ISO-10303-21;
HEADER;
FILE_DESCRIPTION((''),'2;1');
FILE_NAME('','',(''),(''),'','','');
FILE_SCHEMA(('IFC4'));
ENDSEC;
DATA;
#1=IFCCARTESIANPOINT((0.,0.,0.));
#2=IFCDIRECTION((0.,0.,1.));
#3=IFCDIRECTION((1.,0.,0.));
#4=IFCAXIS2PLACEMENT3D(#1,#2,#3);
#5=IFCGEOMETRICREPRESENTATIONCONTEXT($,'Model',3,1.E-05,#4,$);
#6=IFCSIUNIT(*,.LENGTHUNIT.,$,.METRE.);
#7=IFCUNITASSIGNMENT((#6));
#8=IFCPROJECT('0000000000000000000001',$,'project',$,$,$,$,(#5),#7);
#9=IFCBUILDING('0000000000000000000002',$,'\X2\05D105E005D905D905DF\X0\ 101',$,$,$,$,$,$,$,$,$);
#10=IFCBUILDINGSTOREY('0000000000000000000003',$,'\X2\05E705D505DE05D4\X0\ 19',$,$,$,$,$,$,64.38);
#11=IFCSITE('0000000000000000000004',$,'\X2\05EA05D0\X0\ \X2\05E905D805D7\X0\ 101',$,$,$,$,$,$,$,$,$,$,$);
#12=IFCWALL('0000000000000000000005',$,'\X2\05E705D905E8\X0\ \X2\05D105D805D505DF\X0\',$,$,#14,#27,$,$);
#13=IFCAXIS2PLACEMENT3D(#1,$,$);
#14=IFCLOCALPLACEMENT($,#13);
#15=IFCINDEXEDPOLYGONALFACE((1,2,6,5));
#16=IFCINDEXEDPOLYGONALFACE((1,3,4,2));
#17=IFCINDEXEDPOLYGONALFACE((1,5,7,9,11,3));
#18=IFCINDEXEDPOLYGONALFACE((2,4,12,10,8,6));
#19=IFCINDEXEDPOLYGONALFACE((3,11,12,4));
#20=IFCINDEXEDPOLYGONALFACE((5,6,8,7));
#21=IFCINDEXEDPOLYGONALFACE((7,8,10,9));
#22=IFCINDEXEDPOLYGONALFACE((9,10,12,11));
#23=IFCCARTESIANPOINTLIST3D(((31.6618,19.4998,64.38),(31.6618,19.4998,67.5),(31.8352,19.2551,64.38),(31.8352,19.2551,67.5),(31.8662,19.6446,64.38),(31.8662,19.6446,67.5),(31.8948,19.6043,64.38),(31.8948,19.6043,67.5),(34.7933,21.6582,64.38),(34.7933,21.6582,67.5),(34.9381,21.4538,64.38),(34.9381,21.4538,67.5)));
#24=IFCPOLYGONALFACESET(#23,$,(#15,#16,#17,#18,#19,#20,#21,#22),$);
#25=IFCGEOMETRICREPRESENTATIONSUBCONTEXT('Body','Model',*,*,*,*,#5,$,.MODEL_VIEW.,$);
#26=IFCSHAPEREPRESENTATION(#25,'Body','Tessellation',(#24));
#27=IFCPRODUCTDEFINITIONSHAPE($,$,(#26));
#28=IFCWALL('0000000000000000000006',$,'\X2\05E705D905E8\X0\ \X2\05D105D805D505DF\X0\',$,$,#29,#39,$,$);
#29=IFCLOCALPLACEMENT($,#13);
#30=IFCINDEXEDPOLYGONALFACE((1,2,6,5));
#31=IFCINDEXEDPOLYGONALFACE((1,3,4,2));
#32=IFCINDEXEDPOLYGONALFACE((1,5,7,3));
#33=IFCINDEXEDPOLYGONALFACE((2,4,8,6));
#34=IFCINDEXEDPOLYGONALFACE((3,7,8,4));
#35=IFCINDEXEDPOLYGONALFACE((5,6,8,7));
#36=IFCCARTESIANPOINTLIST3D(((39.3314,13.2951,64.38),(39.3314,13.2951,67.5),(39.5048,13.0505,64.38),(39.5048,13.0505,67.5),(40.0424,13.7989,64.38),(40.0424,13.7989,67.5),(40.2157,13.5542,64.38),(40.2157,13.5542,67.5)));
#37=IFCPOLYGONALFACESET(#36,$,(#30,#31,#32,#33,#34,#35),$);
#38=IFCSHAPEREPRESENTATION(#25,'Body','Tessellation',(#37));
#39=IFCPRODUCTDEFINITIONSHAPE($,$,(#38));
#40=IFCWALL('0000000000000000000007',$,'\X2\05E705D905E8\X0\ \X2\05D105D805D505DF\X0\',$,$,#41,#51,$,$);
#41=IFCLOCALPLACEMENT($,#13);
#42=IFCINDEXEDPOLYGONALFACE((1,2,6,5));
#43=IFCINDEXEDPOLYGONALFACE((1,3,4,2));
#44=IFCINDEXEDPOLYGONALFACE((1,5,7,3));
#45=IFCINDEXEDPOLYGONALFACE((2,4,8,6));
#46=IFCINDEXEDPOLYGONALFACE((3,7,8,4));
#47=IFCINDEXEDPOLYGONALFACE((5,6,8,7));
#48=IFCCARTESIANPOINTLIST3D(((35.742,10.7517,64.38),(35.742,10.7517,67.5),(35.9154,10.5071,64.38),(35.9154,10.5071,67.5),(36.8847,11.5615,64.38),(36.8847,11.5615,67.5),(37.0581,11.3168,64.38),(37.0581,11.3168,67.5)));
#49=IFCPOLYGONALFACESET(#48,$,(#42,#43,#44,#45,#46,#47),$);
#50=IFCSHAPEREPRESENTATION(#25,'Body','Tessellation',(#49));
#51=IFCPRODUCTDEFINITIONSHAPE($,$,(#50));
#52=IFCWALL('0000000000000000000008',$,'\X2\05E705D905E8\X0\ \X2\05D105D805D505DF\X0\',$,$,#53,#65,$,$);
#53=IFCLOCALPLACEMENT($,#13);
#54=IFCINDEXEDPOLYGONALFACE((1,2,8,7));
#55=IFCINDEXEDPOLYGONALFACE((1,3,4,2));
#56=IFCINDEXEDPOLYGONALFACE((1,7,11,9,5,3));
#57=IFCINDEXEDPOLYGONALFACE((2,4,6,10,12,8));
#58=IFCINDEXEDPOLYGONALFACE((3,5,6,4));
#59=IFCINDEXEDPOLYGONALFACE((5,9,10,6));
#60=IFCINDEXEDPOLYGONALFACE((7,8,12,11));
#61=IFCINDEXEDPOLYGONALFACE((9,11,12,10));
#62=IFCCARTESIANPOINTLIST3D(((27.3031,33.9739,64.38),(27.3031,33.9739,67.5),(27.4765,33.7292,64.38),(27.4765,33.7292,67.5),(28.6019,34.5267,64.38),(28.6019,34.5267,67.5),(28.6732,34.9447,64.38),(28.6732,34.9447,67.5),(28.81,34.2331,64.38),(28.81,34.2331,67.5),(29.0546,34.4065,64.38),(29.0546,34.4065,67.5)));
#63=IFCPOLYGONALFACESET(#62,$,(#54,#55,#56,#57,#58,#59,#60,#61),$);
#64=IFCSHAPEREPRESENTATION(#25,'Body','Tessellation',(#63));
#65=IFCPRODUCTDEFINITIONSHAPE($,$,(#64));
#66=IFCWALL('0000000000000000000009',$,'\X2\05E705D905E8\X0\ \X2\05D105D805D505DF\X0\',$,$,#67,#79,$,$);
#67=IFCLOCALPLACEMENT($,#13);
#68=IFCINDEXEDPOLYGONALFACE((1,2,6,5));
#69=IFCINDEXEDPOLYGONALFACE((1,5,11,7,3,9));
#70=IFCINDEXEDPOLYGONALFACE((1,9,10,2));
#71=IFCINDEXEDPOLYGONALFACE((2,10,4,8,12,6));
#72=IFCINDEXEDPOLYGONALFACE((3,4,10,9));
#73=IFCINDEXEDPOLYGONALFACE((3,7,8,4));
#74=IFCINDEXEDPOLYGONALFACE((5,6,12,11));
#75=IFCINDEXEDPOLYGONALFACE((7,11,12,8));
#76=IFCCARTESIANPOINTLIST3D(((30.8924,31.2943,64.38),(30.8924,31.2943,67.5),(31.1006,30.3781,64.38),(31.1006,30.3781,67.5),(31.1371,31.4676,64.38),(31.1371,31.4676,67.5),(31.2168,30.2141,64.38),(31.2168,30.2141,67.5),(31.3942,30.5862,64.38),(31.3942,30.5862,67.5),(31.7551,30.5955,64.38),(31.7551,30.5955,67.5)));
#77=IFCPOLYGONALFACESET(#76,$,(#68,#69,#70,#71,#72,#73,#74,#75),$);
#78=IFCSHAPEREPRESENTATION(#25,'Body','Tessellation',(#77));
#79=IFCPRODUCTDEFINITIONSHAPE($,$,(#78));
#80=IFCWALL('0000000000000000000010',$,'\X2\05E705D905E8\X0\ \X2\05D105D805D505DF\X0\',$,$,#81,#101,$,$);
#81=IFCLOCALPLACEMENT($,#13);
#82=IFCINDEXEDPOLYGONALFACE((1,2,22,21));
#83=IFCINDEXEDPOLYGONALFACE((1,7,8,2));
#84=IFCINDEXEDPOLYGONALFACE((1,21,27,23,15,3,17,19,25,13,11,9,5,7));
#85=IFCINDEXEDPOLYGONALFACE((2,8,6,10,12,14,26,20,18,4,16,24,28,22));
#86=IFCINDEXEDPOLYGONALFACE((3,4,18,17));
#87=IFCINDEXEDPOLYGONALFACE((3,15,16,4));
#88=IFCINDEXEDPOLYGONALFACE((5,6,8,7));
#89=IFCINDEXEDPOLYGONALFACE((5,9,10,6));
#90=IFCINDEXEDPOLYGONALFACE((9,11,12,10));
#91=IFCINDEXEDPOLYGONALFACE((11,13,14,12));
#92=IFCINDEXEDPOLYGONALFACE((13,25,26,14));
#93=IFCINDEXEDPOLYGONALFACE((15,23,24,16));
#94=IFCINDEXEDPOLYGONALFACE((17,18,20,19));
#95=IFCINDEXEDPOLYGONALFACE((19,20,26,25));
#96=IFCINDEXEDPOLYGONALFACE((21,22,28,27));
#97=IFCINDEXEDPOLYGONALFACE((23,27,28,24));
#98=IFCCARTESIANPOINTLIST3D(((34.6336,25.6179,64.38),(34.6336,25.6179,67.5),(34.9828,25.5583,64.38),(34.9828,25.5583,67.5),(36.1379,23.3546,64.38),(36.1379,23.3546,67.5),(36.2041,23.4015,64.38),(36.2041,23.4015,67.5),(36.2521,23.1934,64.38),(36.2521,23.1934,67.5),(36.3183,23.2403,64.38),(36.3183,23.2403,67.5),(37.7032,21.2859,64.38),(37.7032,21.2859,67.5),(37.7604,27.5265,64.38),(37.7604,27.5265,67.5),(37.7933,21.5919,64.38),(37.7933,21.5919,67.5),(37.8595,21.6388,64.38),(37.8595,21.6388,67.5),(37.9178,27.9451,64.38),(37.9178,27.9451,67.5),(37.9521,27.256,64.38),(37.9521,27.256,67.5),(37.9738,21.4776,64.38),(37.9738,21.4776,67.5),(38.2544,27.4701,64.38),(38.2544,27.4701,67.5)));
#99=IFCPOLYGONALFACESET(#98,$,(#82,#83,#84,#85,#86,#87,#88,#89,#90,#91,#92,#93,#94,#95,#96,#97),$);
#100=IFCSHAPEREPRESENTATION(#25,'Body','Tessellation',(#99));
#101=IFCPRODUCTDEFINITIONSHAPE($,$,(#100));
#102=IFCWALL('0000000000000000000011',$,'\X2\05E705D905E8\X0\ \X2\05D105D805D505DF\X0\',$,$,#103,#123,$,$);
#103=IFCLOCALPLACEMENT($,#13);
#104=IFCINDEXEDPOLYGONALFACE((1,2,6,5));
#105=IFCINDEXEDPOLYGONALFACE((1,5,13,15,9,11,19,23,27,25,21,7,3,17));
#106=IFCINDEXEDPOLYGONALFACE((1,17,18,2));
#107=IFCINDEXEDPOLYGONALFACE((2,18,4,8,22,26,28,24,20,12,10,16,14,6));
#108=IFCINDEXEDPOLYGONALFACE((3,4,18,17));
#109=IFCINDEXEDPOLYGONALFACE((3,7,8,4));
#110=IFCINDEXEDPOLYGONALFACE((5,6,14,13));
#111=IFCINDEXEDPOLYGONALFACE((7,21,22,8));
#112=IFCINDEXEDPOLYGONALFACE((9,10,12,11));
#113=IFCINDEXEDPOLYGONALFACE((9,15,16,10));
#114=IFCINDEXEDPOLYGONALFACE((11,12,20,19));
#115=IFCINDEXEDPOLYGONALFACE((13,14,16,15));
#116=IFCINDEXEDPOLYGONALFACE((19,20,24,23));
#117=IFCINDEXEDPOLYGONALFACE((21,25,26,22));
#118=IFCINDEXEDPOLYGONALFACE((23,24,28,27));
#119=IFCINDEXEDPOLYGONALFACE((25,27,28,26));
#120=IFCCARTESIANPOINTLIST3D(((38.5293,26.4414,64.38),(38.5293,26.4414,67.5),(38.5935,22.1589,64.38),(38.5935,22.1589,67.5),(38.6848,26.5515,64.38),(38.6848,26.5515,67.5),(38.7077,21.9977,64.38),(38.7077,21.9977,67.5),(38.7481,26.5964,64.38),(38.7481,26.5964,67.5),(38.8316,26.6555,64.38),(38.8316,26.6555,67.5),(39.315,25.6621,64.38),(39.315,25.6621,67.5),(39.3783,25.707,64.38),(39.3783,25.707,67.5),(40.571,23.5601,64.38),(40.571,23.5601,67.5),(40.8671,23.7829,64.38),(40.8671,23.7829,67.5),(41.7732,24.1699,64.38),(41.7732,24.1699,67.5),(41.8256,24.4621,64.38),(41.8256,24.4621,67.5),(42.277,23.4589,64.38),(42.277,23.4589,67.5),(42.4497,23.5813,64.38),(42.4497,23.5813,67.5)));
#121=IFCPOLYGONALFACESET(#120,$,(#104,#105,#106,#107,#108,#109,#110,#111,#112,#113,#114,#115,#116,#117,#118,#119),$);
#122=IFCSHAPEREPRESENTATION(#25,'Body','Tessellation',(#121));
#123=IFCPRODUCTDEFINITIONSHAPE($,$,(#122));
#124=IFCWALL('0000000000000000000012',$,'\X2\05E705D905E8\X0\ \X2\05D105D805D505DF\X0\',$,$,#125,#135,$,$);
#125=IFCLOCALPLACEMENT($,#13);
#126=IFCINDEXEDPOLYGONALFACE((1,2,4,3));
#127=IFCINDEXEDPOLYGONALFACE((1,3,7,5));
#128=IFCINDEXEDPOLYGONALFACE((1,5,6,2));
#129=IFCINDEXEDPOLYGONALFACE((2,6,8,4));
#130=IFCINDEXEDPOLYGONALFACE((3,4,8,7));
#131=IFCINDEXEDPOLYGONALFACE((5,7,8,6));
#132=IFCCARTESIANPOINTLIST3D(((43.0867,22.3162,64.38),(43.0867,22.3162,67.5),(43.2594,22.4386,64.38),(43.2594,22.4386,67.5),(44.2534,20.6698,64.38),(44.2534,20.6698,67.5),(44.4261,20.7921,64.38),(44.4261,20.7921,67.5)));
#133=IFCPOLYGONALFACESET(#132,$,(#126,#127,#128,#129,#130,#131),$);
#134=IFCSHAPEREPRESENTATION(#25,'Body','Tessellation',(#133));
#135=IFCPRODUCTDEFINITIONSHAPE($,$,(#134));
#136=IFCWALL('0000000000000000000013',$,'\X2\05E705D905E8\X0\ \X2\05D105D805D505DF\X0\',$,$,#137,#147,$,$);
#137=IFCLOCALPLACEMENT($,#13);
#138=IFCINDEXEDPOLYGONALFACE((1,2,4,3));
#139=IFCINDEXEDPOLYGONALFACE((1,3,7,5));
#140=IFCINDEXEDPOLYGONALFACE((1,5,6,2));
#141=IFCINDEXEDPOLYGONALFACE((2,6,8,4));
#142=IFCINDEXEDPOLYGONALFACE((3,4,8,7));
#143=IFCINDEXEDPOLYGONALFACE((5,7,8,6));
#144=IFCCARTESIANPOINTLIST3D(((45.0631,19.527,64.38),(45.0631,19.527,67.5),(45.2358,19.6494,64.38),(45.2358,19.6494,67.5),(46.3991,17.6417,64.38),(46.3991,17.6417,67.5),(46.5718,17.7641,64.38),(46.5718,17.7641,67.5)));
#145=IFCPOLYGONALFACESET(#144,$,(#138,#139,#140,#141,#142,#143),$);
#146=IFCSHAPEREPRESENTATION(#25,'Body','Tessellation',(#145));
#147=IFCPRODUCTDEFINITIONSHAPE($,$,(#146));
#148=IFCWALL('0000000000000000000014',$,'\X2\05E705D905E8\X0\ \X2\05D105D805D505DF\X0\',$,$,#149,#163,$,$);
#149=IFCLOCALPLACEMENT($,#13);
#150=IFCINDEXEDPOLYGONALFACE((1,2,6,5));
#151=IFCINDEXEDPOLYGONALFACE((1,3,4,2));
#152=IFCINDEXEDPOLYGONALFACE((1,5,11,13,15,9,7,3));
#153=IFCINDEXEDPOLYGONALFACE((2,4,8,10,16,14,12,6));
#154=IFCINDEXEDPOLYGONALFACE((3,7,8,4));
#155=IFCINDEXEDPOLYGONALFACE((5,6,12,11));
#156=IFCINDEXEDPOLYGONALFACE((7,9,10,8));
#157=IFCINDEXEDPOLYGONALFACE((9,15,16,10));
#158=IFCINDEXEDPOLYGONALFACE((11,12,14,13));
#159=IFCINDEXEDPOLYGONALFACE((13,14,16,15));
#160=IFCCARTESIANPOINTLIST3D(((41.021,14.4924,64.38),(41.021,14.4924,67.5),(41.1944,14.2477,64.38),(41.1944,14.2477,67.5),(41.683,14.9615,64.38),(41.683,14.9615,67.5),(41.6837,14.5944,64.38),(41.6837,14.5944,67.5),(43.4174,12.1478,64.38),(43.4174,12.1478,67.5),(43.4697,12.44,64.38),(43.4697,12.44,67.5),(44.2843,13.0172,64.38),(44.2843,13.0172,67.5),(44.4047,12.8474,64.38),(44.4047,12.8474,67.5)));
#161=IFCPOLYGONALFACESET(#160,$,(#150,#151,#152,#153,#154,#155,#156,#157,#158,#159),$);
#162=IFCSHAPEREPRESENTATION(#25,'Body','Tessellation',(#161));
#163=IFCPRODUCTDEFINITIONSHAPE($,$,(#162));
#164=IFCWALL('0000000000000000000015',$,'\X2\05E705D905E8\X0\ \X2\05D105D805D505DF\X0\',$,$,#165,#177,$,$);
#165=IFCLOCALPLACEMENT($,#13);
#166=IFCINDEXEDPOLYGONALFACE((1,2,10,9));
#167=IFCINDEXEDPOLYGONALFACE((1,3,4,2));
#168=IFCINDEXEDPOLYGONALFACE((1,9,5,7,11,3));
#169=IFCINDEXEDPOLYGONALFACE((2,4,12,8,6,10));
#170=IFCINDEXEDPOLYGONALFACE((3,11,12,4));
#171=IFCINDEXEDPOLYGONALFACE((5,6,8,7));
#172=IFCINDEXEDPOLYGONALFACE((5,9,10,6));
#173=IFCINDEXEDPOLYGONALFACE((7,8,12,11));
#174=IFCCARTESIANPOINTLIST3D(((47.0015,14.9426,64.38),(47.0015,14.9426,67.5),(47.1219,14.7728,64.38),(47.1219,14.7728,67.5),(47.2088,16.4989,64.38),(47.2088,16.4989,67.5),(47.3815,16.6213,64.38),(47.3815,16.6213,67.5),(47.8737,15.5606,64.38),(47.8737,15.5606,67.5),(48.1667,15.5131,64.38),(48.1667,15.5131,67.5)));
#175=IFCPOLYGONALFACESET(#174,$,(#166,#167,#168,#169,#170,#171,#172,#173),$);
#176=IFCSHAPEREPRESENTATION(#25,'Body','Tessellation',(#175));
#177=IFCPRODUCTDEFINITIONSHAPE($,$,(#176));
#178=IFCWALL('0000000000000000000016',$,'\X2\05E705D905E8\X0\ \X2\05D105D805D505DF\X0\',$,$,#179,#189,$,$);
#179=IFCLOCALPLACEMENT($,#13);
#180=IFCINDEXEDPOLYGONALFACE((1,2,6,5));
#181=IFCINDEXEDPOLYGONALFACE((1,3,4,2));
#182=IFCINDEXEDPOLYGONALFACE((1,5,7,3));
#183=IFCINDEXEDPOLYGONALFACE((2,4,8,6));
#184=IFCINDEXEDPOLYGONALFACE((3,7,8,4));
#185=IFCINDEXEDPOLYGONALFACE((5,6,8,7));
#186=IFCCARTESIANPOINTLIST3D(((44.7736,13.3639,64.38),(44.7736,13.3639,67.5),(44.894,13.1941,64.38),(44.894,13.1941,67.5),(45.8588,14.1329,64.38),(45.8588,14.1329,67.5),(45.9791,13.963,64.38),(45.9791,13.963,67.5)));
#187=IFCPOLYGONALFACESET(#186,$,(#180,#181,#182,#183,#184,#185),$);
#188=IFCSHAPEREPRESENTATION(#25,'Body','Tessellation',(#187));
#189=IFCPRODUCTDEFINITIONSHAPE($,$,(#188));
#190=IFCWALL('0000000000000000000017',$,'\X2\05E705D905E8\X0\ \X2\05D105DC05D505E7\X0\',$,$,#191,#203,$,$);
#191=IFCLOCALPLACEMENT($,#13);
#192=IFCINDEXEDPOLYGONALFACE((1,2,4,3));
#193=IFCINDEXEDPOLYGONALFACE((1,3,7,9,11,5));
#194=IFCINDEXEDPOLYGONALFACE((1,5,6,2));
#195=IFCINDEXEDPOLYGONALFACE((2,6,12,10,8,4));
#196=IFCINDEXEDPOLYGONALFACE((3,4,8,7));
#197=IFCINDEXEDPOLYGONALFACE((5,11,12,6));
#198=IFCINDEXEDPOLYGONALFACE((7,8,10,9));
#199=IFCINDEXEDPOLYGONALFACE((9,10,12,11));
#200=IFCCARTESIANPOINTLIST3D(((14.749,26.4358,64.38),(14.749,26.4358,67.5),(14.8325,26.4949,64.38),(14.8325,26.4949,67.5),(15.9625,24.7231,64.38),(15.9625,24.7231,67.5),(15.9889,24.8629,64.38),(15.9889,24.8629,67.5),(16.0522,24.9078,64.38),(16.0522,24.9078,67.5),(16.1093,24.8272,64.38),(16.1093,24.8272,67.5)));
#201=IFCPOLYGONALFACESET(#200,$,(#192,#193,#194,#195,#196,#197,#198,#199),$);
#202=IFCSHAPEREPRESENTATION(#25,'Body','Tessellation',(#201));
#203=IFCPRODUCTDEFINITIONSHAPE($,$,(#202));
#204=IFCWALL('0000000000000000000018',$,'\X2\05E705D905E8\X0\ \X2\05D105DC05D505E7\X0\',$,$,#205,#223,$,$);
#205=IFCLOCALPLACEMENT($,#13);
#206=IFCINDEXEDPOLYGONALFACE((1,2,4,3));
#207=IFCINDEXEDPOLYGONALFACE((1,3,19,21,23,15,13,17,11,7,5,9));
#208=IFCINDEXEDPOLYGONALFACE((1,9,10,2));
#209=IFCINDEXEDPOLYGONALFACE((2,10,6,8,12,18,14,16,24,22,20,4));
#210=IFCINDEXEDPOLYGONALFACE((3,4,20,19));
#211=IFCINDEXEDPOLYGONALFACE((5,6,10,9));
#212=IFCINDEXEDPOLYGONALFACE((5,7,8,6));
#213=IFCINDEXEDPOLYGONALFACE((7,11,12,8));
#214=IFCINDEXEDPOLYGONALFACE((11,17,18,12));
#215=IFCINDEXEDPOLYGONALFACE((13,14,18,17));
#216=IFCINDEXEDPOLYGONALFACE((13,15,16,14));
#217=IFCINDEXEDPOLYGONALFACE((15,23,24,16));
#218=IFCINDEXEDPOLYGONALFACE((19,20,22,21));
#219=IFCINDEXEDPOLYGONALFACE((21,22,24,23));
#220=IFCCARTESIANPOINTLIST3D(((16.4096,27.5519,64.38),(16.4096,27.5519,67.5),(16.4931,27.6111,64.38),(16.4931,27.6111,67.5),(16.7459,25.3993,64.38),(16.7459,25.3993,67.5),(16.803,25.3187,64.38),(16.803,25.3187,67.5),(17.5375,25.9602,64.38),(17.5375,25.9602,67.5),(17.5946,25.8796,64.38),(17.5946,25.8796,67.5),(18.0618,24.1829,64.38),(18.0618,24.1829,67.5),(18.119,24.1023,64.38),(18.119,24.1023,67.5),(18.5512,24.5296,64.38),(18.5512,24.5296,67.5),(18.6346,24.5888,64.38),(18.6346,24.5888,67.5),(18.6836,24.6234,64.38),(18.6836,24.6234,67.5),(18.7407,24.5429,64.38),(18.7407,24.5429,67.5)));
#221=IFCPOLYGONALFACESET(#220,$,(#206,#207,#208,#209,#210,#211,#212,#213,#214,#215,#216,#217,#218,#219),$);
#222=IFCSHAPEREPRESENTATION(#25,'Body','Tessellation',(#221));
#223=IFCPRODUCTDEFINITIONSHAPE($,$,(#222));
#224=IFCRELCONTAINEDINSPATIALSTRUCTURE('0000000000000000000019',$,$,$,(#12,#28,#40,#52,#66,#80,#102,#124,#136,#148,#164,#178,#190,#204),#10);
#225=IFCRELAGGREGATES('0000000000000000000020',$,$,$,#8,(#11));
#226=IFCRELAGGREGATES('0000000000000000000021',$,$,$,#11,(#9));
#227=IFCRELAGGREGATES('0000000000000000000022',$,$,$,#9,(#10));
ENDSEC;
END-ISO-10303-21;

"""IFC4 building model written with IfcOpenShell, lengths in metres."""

from ifc_helpers import new_model, si_unit, frame, origin_with_axes, context, subcontext, project, spatial, polyline, outline, extrude, element, save


model = new_model("IFC4")

# Units and contexts
model_context = context("Model", 3, precision=1e-05, world=origin_with_axes())
body_context = subcontext(model_context, "Body", "Model", "MODEL_VIEW")
ifc_project = project(units=[si_unit("LENGTHUNIT", "METRE")], contexts=[model_context])

# Site, building, storey
site = spatial("IfcSite", under=ifc_project, Name="תא שטח 101")
building = spatial("IfcBuilding", under=site, Name="בניין 101")
storey = spatial("IfcBuildingStorey", under=building, Name="קומה 19", Elevation=64.38)

# Walls
element("IfcWall", 1, inside=storey, Name="קיר בטון", context=body_context, shape_type="SweptSolid", body=[
    extrude(outline(polyline([(31.6618, 19.4998), (31.8352, 19.2551), (34.9381, 21.4538), (34.7933, 21.6582), (31.8948, 19.6043), (31.8662, 19.6446), (31.6618, 19.4998)])), frame((0.0, 0.0, 64.38)), (0.0, 0.0, 1.0), 3.12),
])
element("IfcWall", 2, inside=storey, Name="קיר בטון", context=body_context, shape_type="SweptSolid", body=[
    extrude(outline(polyline([(40.2157, 13.5542), (40.0424, 13.7989), (39.3314, 13.2951), (39.5048, 13.0505), (40.2157, 13.5542)])), frame((0.0, 0.0, 64.38)), (0.0, 0.0, 1.0), 3.12),
])
element("IfcWall", 3, inside=storey, Name="קיר בטון", context=body_context, shape_type="SweptSolid", body=[
    extrude(outline(polyline([(37.0581, 11.3168), (36.8847, 11.5615), (35.742, 10.7517), (35.9154, 10.5071), (37.0581, 11.3168)])), frame((0.0, 0.0, 64.38)), (0.0, 0.0, 1.0), 3.12),
])
element("IfcWall", 4, inside=storey, Name="קיר בטון", context=body_context, shape_type="SweptSolid", body=[
    extrude(outline(polyline([(28.81, 34.2331), (29.0546, 34.4065), (28.6732, 34.9447), (27.3031, 33.9739), (27.4765, 33.7292), (28.6019, 34.5267), (28.81, 34.2331)])), frame((0.0, 0.0, 64.38)), (0.0, 0.0, 1.0), 3.12),
])
element("IfcWall", 5, inside=storey, Name="קיר בטון", context=body_context, shape_type="SweptSolid", body=[
    extrude(outline(polyline([(31.2168, 30.2141), (31.7551, 30.5955), (31.1371, 31.4676), (30.8924, 31.2943), (31.3942, 30.5862), (31.1006, 30.3781), (31.2168, 30.2141)])), frame((0.0, 0.0, 64.38)), (0.0, 0.0, 1.0), 3.12),
])
element("IfcWall", 6, inside=storey, Name="קיר בטון", context=body_context, shape_type="SweptSolid", body=[
    extrude(outline(polyline([(36.2521, 23.1934), (36.3183, 23.2403), (37.7032, 21.2859), (37.9738, 21.4776), (37.8595, 21.6388), (37.7933, 21.5919), (34.9828, 25.5583), (37.7604, 27.5265), (37.9521, 27.256), (38.2544, 27.4701), (37.9178, 27.9451), (34.6336, 25.6179), (36.2041, 23.4015), (36.1379, 23.3546), (36.2521, 23.1934)])), frame((0.0, 0.0, 64.38)), (0.0, 0.0, 1.0), 3.12),
])
element("IfcWall", 7, inside=storey, Name="קיר בטון", context=body_context, shape_type="SweptSolid", body=[
    extrude(outline(polyline([(38.5293, 26.4414), (40.571, 23.5601), (38.5935, 22.1589), (38.7077, 21.9977), (41.7732, 24.1699), (42.277, 23.4589), (42.4497, 23.5813), (41.8256, 24.4621), (40.8671, 23.7829), (38.8316, 26.6555), (38.7481, 26.5964), (39.3783, 25.707), (39.315, 25.6621), (38.6848, 26.5515), (38.5293, 26.4414)])), frame((0.0, 0.0, 64.38)), (0.0, 0.0, 1.0), 3.12),
])
element("IfcWall", 8, inside=storey, Name="קיר בטון", context=body_context, shape_type="SweptSolid", body=[
    extrude(outline(polyline([(43.2594, 22.4386), (43.0867, 22.3162), (44.2534, 20.6698), (44.4261, 20.7921), (43.2594, 22.4386)])), frame((0.0, 0.0, 64.38)), (0.0, 0.0, 1.0), 3.12),
])
element("IfcWall", 9, inside=storey, Name="קיר בטון", context=body_context, shape_type="SweptSolid", body=[
    extrude(outline(polyline([(46.3991, 17.6417), (46.5718, 17.7641), (45.2358, 19.6494), (45.0631, 19.527), (46.3991, 17.6417)])), frame((0.0, 0.0, 64.38)), (0.0, 0.0, 1.0), 3.12),
])
element("IfcWall", 10, inside=storey, Name="קיר בטון", context=body_context, shape_type="SweptSolid", body=[
    extrude(outline(polyline([(43.4174, 12.1478), (44.4047, 12.8474), (44.2843, 13.0172), (43.4697, 12.44), (41.683, 14.9615), (41.021, 14.4924), (41.1944, 14.2477), (41.6837, 14.5944), (43.4174, 12.1478)])), frame((0.0, 0.0, 64.38)), (0.0, 0.0, 1.0), 3.12),
])
element("IfcWall", 11, inside=storey, Name="קיר בטון", context=body_context, shape_type="SweptSolid", body=[
    extrude(outline(polyline([(47.1219, 14.7728), (48.1667, 15.5131), (47.3815, 16.6213), (47.2088, 16.4989), (47.8737, 15.5606), (47.0015, 14.9426), (47.1219, 14.7728)])), frame((0.0, 0.0, 64.38)), (0.0, 0.0, 1.0), 3.12),
])
element("IfcWall", 12, inside=storey, Name="קיר בטון", context=body_context, shape_type="SweptSolid", body=[
    extrude(outline(polyline([(44.7736, 13.3639), (44.894, 13.1941), (45.9791, 13.963), (45.8588, 14.1329), (44.7736, 13.3639)])), frame((0.0, 0.0, 64.38)), (0.0, 0.0, 1.0), 3.12),
])
element("IfcWall", 13, inside=storey, Name="קיר בלוק", context=body_context, shape_type="SweptSolid", body=[
    extrude(outline(polyline([(15.9625, 24.7231), (16.1093, 24.8272), (16.0522, 24.9078), (15.9889, 24.8629), (14.8325, 26.4949), (14.749, 26.4358), (15.9625, 24.7231)])), frame((0.0, 0.0, 64.38)), (0.0, 0.0, 1.0), 3.12),
])
element("IfcWall", 14, inside=storey, Name="קיר בלוק", context=body_context, shape_type="SweptSolid", body=[
    extrude(outline(polyline([(17.5946, 25.8796), (18.5512, 24.5296), (18.0618, 24.1829), (18.119, 24.1023), (18.7407, 24.5429), (18.6836, 24.6234), (18.6346, 24.5888), (16.4931, 27.6111), (16.4096, 27.5519), (17.5375, 25.9602), (16.7459, 25.3993), (16.803, 25.3187), (17.5946, 25.8796)])), frame((0.0, 0.0, 64.38)), (0.0, 0.0, 1.0), 3.12),
])

save(model, "model.ifc")
